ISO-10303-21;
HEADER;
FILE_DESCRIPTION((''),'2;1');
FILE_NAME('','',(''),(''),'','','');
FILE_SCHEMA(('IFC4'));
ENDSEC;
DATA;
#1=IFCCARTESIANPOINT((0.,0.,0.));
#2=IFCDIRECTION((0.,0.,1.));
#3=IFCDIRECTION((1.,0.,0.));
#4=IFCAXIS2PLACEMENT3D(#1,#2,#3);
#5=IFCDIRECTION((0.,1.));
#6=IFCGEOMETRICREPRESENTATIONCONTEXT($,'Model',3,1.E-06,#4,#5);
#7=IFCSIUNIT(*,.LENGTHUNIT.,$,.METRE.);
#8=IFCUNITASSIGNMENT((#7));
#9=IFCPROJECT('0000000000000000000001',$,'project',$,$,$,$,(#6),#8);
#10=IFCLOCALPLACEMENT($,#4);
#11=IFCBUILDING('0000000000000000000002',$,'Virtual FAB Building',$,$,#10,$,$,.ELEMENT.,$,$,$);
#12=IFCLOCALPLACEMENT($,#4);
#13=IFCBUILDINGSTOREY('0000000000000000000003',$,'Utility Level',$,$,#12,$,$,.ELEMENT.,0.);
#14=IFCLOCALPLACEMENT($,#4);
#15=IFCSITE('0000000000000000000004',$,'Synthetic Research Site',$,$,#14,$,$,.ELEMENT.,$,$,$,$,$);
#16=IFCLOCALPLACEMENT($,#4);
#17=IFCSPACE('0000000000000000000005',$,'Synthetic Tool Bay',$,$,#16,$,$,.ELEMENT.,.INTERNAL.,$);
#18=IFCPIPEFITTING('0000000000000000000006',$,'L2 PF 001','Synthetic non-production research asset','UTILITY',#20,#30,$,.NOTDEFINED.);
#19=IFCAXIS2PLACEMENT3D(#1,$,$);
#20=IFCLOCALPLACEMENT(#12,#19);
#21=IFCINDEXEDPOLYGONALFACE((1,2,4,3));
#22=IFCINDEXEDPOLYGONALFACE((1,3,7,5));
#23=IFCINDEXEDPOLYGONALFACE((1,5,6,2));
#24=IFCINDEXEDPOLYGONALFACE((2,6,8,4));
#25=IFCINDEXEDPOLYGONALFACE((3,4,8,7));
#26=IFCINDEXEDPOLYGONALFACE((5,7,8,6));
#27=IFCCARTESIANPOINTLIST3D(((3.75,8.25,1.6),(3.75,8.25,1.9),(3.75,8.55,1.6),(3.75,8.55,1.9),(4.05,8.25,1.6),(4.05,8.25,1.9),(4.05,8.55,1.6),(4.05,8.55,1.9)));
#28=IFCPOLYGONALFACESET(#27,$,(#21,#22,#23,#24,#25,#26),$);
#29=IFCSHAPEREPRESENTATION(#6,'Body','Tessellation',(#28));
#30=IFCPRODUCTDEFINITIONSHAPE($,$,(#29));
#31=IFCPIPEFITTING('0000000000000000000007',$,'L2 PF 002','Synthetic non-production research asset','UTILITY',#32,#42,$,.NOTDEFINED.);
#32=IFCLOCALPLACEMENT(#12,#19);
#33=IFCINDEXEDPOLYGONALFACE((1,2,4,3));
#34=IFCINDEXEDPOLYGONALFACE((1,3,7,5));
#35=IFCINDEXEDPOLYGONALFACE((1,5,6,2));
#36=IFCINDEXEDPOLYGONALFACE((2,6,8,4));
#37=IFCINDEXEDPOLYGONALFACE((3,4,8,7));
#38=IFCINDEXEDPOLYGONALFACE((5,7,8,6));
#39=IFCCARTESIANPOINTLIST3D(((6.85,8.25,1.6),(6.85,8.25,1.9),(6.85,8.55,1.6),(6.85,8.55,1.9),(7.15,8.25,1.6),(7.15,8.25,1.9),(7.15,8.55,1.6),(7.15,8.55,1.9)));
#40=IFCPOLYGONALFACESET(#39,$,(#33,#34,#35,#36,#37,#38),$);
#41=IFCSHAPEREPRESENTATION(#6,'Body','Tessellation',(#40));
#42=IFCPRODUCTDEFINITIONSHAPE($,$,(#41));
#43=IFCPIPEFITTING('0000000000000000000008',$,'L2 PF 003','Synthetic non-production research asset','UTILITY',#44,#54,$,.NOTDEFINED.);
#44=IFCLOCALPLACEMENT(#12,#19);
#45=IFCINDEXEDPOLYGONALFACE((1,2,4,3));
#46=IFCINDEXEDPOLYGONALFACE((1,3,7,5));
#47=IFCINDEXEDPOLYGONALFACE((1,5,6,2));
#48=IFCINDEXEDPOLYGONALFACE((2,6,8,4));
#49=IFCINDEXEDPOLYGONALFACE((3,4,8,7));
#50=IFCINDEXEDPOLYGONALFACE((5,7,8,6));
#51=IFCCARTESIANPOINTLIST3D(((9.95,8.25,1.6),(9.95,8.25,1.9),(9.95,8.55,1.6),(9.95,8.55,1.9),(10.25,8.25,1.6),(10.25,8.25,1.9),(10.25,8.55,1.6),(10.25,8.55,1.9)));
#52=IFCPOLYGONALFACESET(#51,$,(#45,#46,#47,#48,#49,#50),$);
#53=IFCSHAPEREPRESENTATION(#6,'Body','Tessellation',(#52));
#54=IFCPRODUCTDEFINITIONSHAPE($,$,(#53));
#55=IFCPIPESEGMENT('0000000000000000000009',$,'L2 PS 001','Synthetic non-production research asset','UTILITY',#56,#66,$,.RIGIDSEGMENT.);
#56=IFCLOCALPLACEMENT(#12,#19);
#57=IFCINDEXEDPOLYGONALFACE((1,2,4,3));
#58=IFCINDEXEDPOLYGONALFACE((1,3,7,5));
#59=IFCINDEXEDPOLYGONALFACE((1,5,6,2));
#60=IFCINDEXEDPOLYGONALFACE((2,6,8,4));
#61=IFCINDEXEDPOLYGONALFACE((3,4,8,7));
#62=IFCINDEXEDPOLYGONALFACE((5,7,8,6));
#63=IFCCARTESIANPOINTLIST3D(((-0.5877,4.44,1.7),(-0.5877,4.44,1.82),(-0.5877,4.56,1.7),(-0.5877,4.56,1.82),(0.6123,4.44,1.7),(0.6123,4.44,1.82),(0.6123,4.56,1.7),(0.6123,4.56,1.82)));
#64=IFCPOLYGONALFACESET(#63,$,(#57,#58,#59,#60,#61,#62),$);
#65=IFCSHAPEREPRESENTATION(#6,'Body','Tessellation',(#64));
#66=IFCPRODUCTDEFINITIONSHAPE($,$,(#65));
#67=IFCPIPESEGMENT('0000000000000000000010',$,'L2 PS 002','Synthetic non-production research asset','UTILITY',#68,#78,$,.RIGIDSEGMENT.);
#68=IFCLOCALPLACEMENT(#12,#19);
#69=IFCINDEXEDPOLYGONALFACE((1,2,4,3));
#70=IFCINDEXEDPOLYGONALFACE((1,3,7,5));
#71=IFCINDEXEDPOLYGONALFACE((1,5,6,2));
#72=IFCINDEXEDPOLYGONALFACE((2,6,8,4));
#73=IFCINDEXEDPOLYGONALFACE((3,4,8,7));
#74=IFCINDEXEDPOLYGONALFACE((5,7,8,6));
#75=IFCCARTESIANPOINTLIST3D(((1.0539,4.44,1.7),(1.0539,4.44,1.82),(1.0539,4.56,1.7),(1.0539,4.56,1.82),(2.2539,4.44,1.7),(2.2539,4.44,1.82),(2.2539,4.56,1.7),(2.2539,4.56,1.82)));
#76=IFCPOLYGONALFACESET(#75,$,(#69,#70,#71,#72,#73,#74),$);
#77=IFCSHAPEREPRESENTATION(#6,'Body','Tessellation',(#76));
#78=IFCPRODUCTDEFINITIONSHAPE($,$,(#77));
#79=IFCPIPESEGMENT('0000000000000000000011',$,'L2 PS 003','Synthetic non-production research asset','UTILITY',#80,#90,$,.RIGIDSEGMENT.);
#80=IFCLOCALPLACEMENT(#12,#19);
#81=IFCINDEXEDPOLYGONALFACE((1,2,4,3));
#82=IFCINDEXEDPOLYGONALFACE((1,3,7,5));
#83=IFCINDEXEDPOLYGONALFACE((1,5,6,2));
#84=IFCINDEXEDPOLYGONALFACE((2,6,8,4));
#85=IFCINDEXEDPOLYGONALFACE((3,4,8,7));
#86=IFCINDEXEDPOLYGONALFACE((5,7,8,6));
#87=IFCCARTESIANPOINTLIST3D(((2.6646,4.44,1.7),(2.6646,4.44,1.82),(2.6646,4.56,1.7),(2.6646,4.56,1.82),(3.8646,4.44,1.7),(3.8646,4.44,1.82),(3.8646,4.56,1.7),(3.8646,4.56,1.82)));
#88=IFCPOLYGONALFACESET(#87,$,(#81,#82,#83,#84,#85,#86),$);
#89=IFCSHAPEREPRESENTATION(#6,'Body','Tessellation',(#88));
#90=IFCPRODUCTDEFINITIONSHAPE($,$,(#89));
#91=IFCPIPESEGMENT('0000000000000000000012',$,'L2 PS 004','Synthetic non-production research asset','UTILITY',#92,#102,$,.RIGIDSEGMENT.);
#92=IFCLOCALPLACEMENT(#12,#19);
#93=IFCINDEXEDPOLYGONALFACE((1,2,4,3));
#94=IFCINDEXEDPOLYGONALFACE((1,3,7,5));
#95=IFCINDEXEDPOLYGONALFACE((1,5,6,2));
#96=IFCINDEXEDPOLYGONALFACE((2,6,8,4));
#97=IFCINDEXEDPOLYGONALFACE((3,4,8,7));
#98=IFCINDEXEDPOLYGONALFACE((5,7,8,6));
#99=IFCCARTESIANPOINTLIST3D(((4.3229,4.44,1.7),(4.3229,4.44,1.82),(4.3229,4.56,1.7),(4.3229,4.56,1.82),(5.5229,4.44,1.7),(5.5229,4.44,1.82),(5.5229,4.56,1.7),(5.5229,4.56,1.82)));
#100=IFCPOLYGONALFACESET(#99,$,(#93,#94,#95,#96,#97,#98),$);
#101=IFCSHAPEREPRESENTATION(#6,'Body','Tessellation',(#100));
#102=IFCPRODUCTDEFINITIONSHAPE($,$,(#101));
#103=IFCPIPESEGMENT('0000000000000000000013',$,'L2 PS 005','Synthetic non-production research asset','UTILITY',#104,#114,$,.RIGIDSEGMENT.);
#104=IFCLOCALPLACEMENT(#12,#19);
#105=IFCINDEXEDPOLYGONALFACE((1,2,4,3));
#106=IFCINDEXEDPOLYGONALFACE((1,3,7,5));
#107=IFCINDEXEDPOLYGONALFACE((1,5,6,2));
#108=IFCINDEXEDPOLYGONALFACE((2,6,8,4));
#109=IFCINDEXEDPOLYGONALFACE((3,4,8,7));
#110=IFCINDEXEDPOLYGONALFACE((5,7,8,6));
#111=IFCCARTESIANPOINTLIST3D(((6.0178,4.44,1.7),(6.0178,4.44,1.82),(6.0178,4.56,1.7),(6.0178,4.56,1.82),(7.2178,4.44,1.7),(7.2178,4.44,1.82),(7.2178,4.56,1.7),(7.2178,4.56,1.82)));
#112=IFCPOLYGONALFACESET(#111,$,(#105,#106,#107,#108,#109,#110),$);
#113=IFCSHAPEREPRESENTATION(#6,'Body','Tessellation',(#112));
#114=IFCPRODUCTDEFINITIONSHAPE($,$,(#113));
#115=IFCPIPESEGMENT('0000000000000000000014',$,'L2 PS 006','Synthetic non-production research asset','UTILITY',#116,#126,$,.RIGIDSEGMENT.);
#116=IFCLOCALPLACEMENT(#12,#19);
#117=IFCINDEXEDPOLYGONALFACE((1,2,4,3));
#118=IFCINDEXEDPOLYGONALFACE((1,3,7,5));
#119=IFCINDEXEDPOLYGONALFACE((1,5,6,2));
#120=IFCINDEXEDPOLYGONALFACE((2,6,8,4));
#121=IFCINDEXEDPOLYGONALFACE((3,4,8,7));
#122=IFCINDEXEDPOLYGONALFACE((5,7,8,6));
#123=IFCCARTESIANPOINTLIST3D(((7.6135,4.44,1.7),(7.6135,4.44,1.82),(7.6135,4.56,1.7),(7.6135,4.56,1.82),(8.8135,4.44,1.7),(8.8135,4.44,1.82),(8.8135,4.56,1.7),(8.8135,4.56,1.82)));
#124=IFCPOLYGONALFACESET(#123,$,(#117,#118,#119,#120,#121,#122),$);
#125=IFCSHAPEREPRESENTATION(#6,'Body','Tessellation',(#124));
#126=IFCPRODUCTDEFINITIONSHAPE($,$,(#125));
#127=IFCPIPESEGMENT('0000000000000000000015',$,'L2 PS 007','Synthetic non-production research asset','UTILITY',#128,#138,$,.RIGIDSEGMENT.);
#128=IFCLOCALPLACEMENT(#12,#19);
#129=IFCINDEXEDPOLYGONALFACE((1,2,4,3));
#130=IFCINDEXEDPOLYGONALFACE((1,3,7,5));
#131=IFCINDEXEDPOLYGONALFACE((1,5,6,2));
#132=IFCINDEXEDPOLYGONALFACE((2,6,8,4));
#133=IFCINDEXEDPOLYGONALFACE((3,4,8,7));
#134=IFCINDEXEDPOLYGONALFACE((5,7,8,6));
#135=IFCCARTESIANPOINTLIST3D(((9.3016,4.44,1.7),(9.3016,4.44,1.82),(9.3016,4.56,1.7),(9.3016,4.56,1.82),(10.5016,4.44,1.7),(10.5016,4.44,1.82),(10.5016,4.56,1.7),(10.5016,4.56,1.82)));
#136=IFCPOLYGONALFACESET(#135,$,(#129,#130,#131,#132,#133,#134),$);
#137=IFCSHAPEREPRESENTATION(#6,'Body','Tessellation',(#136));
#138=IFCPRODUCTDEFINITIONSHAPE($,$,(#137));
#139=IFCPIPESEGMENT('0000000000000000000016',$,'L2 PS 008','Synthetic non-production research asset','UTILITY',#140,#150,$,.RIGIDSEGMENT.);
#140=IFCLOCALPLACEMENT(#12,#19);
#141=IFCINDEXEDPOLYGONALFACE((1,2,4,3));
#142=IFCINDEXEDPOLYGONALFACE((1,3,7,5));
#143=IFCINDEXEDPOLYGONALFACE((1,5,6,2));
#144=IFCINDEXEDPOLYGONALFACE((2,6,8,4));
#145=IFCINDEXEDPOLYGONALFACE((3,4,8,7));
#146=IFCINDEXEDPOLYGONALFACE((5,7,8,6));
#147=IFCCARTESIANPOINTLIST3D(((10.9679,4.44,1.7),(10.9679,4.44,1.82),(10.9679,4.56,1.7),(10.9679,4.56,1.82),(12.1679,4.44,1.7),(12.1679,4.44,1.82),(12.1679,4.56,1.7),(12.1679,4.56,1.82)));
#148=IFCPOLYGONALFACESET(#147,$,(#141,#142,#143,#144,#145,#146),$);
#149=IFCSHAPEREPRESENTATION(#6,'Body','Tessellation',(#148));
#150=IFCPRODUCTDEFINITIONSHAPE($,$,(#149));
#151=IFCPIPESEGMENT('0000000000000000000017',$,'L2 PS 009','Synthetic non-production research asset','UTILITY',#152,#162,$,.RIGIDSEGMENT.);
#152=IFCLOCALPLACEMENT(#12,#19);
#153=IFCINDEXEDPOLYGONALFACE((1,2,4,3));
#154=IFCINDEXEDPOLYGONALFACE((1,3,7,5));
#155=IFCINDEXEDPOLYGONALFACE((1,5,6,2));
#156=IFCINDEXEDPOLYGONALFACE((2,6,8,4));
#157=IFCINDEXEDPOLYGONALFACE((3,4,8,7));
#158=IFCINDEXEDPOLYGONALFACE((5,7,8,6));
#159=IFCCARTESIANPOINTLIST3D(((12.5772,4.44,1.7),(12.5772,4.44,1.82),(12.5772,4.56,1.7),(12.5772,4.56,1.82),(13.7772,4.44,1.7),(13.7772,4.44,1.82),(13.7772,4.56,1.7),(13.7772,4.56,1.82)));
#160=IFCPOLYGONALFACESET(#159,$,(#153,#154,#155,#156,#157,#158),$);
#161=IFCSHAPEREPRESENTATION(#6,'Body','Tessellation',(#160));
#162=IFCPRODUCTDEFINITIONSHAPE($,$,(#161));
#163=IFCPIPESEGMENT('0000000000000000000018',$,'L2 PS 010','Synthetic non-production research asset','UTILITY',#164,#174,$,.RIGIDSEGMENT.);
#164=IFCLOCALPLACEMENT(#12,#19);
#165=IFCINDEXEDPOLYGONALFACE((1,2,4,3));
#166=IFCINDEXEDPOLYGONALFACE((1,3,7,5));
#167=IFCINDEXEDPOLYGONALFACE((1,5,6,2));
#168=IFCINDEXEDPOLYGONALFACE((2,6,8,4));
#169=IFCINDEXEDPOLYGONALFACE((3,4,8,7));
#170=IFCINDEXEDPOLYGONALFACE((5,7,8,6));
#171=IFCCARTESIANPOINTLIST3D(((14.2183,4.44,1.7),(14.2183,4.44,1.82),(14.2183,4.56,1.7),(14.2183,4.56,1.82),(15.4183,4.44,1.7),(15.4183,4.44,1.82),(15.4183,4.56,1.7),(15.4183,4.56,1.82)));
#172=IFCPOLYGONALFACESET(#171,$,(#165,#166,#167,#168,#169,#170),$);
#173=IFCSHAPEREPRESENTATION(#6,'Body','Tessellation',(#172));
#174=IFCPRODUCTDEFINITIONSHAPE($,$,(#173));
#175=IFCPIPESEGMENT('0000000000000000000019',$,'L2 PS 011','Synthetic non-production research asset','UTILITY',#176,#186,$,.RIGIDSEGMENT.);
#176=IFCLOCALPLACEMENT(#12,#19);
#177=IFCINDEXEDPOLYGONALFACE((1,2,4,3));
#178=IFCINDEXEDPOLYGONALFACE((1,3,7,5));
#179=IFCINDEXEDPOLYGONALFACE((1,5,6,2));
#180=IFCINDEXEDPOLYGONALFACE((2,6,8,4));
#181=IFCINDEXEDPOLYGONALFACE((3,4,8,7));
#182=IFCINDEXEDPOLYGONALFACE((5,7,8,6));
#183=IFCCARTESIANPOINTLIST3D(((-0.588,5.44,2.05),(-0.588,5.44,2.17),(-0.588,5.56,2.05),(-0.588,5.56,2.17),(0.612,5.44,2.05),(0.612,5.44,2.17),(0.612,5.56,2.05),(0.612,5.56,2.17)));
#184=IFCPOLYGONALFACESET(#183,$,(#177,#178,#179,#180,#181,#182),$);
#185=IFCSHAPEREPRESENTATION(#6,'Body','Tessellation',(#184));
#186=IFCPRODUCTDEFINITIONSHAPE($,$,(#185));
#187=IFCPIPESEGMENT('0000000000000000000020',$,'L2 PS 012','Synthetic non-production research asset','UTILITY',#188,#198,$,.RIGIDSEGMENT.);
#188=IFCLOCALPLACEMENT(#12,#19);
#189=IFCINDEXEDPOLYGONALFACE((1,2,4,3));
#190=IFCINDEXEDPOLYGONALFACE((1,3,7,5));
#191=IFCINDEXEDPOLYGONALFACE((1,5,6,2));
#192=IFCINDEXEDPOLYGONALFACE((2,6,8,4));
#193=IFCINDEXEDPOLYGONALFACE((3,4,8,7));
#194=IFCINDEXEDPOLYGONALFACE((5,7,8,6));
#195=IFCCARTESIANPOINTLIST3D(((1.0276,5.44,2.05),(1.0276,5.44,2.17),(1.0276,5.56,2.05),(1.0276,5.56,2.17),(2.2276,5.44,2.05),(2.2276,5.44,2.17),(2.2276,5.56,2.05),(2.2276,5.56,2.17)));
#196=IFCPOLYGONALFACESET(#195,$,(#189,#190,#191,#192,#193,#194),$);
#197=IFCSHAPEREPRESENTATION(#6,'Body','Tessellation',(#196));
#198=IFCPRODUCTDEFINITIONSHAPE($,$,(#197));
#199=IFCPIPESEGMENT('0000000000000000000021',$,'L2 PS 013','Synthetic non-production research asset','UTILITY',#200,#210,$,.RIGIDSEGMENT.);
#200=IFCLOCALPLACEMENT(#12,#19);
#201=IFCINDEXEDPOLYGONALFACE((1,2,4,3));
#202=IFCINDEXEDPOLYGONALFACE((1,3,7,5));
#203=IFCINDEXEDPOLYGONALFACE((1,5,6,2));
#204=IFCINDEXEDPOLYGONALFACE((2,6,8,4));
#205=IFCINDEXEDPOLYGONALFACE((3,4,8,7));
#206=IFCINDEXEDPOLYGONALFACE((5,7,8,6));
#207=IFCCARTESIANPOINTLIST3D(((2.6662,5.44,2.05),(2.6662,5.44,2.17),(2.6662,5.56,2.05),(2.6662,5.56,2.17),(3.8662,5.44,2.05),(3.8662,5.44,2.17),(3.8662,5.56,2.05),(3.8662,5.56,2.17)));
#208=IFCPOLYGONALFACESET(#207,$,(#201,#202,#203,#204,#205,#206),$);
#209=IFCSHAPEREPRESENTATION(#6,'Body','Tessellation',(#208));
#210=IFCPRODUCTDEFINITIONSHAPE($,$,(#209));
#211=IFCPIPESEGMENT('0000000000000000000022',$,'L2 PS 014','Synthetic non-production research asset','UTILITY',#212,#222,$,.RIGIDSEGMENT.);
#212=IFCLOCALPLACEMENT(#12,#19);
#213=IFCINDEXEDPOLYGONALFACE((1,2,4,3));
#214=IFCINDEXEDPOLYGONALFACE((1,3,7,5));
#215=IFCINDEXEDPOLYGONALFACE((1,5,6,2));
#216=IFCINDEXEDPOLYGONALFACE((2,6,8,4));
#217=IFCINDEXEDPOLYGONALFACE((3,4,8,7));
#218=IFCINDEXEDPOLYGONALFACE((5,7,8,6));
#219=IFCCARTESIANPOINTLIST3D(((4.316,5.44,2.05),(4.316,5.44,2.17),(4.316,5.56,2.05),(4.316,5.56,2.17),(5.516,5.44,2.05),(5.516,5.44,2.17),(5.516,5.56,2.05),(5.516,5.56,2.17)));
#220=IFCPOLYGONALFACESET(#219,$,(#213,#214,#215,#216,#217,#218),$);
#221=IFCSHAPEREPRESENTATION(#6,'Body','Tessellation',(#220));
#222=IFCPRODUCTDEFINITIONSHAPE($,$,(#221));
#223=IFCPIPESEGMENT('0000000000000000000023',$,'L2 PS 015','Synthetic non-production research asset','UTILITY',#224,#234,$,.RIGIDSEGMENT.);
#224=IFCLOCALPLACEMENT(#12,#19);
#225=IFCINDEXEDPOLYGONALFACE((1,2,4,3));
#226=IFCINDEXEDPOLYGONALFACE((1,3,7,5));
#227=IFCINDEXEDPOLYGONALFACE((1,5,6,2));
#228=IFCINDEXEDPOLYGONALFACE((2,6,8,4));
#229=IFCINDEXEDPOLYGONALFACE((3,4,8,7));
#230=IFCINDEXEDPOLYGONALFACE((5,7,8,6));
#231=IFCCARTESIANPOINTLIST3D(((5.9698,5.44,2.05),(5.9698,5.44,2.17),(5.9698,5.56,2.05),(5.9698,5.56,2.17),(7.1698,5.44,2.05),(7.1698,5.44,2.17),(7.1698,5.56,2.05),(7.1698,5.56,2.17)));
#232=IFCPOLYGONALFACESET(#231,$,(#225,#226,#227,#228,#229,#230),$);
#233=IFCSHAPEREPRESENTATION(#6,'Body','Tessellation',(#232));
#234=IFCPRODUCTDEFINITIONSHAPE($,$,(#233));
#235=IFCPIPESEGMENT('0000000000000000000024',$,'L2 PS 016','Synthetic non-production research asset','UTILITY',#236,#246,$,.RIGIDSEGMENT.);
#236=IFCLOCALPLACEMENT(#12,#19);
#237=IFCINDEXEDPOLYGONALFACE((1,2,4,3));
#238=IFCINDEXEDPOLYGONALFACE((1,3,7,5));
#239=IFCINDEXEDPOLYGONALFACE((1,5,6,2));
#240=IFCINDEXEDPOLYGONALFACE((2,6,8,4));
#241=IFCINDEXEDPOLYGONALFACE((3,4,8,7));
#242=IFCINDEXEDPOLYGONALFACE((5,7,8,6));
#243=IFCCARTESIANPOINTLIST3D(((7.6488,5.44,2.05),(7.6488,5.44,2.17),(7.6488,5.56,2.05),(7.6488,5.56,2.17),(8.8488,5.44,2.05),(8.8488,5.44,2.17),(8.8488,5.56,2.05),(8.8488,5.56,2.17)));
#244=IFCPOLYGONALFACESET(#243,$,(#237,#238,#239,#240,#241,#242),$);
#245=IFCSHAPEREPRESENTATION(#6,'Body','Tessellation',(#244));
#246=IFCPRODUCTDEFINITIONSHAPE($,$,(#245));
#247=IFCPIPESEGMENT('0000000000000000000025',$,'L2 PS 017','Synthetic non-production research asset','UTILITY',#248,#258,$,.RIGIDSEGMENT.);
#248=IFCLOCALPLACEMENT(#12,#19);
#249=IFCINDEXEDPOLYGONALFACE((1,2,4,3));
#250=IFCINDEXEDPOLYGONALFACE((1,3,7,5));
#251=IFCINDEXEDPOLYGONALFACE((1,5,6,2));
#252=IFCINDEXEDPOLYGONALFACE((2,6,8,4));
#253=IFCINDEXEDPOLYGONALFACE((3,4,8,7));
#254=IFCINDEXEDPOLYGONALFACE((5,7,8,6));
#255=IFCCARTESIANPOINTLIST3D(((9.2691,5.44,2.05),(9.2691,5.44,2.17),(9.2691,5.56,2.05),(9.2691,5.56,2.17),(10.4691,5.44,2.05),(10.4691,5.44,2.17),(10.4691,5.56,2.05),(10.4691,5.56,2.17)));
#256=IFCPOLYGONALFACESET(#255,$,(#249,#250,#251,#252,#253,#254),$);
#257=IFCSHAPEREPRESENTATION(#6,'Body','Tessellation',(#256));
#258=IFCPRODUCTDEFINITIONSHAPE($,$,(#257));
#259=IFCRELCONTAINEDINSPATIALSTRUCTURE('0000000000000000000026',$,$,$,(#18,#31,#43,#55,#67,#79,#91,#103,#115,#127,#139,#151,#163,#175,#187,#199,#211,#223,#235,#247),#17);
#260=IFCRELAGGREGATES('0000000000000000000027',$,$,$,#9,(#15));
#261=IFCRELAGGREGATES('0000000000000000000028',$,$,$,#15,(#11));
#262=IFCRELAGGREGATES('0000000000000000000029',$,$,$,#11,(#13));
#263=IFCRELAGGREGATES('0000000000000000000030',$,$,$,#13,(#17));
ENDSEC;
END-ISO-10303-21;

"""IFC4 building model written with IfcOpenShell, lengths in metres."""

from ifc_helpers import new_model, si_unit, direction, frame, origin_with_axes, origin_2d_with_axis, place, context, project, spatial, rectangle, extrude, element, save


model = new_model("IFC4")

# Units and contexts
model_context = context("Model", 3, precision=1e-06, world=origin_with_axes(), true_north=direction((0.0, 1.0)))
ifc_project = project(units=[si_unit("LENGTHUNIT", "METRE")], contexts=[model_context])

# Site, building, storey, space
site_placement = place(None, origin_with_axes())
site = spatial("IfcSite", under=ifc_project, at=site_placement, Name="Synthetic Research Site", CompositionType="ELEMENT")
building_placement = place(None, origin_with_axes())
building = spatial("IfcBuilding", under=site, at=building_placement, Name="Virtual FAB Building", CompositionType="ELEMENT")
storey_placement = place(None, origin_with_axes())
storey = spatial("IfcBuildingStorey", under=building, at=storey_placement, Name="Utility Level", CompositionType="ELEMENT", Elevation=0.0)
space_placement = place(None, origin_with_axes())
space = spatial("IfcSpace", under=storey, at=space_placement, Name="Synthetic Tool Bay", CompositionType="ELEMENT", PredefinedType="INTERNAL")

# Pipe fittings
for number, where, z_axis, x_axis, name in (
    (1, (3.9, 8.4, 1.6), (0.0, 0.0, 1.0), (1.0, 0.0, 0.0), "L2 PF 001"),
    (2, (7.0, 8.4, 1.6), (0.0, 0.0, 1.0), (1.0, 0.0, 0.0), "L2 PF 002"),
    (3, (10.1, 8.4, 1.6), (0.0, 0.0, 1.0), (1.0, 0.0, 0.0), "L2 PF 003"),
):
    element("IfcPipeFitting", number, at=place(None, frame(where, z_axis=z_axis, x_axis=x_axis)), inside=space, Name=name, Description="Synthetic non-production research asset", ObjectType="UTILITY", PredefinedType="NOTDEFINED", context=model_context, shape_type="SweptSolid", body=[
        extrude(rectangle(XDim=0.3, YDim=0.3, at=origin_2d_with_axis()), origin_with_axes(), (0.0, 0.0, 1.0), 0.3),
    ])

# Pipe segments
for number, where, z_axis, x_axis, name in (
    (4, (0.0123, 4.5, 1.7), (0.0, 0.0, 1.0), (1.0, 0.0, 0.0), "L2 PS 001"),
    (5, (1.6539, 4.5, 1.7), (0.0, 0.0, 1.0), (1.0, 0.0, 0.0), "L2 PS 002"),
    (6, (3.2646, 4.5, 1.7), (0.0, 0.0, 1.0), (1.0, 0.0, 0.0), "L2 PS 003"),
    (7, (4.9229, 4.5, 1.7), (0.0, 0.0, 1.0), (1.0, 0.0, 0.0), "L2 PS 004"),
    (8, (6.6178, 4.5, 1.7), (0.0, 0.0, 1.0), (1.0, 0.0, 0.0), "L2 PS 005"),
    (9, (8.2135, 4.5, 1.7), (0.0, 0.0, 1.0), (1.0, 0.0, 0.0), "L2 PS 006"),
    (10, (9.9016, 4.5, 1.7), (0.0, 0.0, 1.0), (1.0, 0.0, 0.0), "L2 PS 007"),
    (11, (11.5679, 4.5, 1.7), (0.0, 0.0, 1.0), (1.0, 0.0, 0.0), "L2 PS 008"),
    (12, (13.1772, 4.5, 1.7), (0.0, 0.0, 1.0), (1.0, 0.0, 0.0), "L2 PS 009"),
    (13, (14.8183, 4.5, 1.7), (0.0, 0.0, 1.0), (1.0, 0.0, 0.0), "L2 PS 010"),
    (14, (0.012, 5.5, 2.05), (0.0, 0.0, 1.0), (1.0, 0.0, 0.0), "L2 PS 011"),
    (15, (1.6276, 5.5, 2.05), (0.0, 0.0, 1.0), (1.0, 0.0, 0.0), "L2 PS 012"),
    (16, (3.2662, 5.5, 2.05), (0.0, 0.0, 1.0), (1.0, 0.0, 0.0), "L2 PS 013"),
    (17, (4.916, 5.5, 2.05), (0.0, 0.0, 1.0), (1.0, 0.0, 0.0), "L2 PS 014"),
    (18, (6.5698, 5.5, 2.05), (0.0, 0.0, 1.0), (1.0, 0.0, 0.0), "L2 PS 015"),
    (19, (8.2488, 5.5, 2.05), (0.0, 0.0, 1.0), (1.0, 0.0, 0.0), "L2 PS 016"),
    (20, (9.8691, 5.5, 2.05), (0.0, 0.0, 1.0), (1.0, 0.0, 0.0), "L2 PS 017"),
):
    element("IfcPipeSegment", number, at=place(None, frame(where, z_axis=z_axis, x_axis=x_axis)), inside=space, Name=name, Description="Synthetic non-production research asset", ObjectType="UTILITY", PredefinedType="RIGIDSEGMENT", context=model_context, shape_type="SweptSolid", body=[
        extrude(rectangle(XDim=1.2, YDim=0.12, at=origin_2d_with_axis()), origin_with_axes(), (0.0, 0.0, 1.0), 0.12),
    ])

save(model, "model.ifc")
